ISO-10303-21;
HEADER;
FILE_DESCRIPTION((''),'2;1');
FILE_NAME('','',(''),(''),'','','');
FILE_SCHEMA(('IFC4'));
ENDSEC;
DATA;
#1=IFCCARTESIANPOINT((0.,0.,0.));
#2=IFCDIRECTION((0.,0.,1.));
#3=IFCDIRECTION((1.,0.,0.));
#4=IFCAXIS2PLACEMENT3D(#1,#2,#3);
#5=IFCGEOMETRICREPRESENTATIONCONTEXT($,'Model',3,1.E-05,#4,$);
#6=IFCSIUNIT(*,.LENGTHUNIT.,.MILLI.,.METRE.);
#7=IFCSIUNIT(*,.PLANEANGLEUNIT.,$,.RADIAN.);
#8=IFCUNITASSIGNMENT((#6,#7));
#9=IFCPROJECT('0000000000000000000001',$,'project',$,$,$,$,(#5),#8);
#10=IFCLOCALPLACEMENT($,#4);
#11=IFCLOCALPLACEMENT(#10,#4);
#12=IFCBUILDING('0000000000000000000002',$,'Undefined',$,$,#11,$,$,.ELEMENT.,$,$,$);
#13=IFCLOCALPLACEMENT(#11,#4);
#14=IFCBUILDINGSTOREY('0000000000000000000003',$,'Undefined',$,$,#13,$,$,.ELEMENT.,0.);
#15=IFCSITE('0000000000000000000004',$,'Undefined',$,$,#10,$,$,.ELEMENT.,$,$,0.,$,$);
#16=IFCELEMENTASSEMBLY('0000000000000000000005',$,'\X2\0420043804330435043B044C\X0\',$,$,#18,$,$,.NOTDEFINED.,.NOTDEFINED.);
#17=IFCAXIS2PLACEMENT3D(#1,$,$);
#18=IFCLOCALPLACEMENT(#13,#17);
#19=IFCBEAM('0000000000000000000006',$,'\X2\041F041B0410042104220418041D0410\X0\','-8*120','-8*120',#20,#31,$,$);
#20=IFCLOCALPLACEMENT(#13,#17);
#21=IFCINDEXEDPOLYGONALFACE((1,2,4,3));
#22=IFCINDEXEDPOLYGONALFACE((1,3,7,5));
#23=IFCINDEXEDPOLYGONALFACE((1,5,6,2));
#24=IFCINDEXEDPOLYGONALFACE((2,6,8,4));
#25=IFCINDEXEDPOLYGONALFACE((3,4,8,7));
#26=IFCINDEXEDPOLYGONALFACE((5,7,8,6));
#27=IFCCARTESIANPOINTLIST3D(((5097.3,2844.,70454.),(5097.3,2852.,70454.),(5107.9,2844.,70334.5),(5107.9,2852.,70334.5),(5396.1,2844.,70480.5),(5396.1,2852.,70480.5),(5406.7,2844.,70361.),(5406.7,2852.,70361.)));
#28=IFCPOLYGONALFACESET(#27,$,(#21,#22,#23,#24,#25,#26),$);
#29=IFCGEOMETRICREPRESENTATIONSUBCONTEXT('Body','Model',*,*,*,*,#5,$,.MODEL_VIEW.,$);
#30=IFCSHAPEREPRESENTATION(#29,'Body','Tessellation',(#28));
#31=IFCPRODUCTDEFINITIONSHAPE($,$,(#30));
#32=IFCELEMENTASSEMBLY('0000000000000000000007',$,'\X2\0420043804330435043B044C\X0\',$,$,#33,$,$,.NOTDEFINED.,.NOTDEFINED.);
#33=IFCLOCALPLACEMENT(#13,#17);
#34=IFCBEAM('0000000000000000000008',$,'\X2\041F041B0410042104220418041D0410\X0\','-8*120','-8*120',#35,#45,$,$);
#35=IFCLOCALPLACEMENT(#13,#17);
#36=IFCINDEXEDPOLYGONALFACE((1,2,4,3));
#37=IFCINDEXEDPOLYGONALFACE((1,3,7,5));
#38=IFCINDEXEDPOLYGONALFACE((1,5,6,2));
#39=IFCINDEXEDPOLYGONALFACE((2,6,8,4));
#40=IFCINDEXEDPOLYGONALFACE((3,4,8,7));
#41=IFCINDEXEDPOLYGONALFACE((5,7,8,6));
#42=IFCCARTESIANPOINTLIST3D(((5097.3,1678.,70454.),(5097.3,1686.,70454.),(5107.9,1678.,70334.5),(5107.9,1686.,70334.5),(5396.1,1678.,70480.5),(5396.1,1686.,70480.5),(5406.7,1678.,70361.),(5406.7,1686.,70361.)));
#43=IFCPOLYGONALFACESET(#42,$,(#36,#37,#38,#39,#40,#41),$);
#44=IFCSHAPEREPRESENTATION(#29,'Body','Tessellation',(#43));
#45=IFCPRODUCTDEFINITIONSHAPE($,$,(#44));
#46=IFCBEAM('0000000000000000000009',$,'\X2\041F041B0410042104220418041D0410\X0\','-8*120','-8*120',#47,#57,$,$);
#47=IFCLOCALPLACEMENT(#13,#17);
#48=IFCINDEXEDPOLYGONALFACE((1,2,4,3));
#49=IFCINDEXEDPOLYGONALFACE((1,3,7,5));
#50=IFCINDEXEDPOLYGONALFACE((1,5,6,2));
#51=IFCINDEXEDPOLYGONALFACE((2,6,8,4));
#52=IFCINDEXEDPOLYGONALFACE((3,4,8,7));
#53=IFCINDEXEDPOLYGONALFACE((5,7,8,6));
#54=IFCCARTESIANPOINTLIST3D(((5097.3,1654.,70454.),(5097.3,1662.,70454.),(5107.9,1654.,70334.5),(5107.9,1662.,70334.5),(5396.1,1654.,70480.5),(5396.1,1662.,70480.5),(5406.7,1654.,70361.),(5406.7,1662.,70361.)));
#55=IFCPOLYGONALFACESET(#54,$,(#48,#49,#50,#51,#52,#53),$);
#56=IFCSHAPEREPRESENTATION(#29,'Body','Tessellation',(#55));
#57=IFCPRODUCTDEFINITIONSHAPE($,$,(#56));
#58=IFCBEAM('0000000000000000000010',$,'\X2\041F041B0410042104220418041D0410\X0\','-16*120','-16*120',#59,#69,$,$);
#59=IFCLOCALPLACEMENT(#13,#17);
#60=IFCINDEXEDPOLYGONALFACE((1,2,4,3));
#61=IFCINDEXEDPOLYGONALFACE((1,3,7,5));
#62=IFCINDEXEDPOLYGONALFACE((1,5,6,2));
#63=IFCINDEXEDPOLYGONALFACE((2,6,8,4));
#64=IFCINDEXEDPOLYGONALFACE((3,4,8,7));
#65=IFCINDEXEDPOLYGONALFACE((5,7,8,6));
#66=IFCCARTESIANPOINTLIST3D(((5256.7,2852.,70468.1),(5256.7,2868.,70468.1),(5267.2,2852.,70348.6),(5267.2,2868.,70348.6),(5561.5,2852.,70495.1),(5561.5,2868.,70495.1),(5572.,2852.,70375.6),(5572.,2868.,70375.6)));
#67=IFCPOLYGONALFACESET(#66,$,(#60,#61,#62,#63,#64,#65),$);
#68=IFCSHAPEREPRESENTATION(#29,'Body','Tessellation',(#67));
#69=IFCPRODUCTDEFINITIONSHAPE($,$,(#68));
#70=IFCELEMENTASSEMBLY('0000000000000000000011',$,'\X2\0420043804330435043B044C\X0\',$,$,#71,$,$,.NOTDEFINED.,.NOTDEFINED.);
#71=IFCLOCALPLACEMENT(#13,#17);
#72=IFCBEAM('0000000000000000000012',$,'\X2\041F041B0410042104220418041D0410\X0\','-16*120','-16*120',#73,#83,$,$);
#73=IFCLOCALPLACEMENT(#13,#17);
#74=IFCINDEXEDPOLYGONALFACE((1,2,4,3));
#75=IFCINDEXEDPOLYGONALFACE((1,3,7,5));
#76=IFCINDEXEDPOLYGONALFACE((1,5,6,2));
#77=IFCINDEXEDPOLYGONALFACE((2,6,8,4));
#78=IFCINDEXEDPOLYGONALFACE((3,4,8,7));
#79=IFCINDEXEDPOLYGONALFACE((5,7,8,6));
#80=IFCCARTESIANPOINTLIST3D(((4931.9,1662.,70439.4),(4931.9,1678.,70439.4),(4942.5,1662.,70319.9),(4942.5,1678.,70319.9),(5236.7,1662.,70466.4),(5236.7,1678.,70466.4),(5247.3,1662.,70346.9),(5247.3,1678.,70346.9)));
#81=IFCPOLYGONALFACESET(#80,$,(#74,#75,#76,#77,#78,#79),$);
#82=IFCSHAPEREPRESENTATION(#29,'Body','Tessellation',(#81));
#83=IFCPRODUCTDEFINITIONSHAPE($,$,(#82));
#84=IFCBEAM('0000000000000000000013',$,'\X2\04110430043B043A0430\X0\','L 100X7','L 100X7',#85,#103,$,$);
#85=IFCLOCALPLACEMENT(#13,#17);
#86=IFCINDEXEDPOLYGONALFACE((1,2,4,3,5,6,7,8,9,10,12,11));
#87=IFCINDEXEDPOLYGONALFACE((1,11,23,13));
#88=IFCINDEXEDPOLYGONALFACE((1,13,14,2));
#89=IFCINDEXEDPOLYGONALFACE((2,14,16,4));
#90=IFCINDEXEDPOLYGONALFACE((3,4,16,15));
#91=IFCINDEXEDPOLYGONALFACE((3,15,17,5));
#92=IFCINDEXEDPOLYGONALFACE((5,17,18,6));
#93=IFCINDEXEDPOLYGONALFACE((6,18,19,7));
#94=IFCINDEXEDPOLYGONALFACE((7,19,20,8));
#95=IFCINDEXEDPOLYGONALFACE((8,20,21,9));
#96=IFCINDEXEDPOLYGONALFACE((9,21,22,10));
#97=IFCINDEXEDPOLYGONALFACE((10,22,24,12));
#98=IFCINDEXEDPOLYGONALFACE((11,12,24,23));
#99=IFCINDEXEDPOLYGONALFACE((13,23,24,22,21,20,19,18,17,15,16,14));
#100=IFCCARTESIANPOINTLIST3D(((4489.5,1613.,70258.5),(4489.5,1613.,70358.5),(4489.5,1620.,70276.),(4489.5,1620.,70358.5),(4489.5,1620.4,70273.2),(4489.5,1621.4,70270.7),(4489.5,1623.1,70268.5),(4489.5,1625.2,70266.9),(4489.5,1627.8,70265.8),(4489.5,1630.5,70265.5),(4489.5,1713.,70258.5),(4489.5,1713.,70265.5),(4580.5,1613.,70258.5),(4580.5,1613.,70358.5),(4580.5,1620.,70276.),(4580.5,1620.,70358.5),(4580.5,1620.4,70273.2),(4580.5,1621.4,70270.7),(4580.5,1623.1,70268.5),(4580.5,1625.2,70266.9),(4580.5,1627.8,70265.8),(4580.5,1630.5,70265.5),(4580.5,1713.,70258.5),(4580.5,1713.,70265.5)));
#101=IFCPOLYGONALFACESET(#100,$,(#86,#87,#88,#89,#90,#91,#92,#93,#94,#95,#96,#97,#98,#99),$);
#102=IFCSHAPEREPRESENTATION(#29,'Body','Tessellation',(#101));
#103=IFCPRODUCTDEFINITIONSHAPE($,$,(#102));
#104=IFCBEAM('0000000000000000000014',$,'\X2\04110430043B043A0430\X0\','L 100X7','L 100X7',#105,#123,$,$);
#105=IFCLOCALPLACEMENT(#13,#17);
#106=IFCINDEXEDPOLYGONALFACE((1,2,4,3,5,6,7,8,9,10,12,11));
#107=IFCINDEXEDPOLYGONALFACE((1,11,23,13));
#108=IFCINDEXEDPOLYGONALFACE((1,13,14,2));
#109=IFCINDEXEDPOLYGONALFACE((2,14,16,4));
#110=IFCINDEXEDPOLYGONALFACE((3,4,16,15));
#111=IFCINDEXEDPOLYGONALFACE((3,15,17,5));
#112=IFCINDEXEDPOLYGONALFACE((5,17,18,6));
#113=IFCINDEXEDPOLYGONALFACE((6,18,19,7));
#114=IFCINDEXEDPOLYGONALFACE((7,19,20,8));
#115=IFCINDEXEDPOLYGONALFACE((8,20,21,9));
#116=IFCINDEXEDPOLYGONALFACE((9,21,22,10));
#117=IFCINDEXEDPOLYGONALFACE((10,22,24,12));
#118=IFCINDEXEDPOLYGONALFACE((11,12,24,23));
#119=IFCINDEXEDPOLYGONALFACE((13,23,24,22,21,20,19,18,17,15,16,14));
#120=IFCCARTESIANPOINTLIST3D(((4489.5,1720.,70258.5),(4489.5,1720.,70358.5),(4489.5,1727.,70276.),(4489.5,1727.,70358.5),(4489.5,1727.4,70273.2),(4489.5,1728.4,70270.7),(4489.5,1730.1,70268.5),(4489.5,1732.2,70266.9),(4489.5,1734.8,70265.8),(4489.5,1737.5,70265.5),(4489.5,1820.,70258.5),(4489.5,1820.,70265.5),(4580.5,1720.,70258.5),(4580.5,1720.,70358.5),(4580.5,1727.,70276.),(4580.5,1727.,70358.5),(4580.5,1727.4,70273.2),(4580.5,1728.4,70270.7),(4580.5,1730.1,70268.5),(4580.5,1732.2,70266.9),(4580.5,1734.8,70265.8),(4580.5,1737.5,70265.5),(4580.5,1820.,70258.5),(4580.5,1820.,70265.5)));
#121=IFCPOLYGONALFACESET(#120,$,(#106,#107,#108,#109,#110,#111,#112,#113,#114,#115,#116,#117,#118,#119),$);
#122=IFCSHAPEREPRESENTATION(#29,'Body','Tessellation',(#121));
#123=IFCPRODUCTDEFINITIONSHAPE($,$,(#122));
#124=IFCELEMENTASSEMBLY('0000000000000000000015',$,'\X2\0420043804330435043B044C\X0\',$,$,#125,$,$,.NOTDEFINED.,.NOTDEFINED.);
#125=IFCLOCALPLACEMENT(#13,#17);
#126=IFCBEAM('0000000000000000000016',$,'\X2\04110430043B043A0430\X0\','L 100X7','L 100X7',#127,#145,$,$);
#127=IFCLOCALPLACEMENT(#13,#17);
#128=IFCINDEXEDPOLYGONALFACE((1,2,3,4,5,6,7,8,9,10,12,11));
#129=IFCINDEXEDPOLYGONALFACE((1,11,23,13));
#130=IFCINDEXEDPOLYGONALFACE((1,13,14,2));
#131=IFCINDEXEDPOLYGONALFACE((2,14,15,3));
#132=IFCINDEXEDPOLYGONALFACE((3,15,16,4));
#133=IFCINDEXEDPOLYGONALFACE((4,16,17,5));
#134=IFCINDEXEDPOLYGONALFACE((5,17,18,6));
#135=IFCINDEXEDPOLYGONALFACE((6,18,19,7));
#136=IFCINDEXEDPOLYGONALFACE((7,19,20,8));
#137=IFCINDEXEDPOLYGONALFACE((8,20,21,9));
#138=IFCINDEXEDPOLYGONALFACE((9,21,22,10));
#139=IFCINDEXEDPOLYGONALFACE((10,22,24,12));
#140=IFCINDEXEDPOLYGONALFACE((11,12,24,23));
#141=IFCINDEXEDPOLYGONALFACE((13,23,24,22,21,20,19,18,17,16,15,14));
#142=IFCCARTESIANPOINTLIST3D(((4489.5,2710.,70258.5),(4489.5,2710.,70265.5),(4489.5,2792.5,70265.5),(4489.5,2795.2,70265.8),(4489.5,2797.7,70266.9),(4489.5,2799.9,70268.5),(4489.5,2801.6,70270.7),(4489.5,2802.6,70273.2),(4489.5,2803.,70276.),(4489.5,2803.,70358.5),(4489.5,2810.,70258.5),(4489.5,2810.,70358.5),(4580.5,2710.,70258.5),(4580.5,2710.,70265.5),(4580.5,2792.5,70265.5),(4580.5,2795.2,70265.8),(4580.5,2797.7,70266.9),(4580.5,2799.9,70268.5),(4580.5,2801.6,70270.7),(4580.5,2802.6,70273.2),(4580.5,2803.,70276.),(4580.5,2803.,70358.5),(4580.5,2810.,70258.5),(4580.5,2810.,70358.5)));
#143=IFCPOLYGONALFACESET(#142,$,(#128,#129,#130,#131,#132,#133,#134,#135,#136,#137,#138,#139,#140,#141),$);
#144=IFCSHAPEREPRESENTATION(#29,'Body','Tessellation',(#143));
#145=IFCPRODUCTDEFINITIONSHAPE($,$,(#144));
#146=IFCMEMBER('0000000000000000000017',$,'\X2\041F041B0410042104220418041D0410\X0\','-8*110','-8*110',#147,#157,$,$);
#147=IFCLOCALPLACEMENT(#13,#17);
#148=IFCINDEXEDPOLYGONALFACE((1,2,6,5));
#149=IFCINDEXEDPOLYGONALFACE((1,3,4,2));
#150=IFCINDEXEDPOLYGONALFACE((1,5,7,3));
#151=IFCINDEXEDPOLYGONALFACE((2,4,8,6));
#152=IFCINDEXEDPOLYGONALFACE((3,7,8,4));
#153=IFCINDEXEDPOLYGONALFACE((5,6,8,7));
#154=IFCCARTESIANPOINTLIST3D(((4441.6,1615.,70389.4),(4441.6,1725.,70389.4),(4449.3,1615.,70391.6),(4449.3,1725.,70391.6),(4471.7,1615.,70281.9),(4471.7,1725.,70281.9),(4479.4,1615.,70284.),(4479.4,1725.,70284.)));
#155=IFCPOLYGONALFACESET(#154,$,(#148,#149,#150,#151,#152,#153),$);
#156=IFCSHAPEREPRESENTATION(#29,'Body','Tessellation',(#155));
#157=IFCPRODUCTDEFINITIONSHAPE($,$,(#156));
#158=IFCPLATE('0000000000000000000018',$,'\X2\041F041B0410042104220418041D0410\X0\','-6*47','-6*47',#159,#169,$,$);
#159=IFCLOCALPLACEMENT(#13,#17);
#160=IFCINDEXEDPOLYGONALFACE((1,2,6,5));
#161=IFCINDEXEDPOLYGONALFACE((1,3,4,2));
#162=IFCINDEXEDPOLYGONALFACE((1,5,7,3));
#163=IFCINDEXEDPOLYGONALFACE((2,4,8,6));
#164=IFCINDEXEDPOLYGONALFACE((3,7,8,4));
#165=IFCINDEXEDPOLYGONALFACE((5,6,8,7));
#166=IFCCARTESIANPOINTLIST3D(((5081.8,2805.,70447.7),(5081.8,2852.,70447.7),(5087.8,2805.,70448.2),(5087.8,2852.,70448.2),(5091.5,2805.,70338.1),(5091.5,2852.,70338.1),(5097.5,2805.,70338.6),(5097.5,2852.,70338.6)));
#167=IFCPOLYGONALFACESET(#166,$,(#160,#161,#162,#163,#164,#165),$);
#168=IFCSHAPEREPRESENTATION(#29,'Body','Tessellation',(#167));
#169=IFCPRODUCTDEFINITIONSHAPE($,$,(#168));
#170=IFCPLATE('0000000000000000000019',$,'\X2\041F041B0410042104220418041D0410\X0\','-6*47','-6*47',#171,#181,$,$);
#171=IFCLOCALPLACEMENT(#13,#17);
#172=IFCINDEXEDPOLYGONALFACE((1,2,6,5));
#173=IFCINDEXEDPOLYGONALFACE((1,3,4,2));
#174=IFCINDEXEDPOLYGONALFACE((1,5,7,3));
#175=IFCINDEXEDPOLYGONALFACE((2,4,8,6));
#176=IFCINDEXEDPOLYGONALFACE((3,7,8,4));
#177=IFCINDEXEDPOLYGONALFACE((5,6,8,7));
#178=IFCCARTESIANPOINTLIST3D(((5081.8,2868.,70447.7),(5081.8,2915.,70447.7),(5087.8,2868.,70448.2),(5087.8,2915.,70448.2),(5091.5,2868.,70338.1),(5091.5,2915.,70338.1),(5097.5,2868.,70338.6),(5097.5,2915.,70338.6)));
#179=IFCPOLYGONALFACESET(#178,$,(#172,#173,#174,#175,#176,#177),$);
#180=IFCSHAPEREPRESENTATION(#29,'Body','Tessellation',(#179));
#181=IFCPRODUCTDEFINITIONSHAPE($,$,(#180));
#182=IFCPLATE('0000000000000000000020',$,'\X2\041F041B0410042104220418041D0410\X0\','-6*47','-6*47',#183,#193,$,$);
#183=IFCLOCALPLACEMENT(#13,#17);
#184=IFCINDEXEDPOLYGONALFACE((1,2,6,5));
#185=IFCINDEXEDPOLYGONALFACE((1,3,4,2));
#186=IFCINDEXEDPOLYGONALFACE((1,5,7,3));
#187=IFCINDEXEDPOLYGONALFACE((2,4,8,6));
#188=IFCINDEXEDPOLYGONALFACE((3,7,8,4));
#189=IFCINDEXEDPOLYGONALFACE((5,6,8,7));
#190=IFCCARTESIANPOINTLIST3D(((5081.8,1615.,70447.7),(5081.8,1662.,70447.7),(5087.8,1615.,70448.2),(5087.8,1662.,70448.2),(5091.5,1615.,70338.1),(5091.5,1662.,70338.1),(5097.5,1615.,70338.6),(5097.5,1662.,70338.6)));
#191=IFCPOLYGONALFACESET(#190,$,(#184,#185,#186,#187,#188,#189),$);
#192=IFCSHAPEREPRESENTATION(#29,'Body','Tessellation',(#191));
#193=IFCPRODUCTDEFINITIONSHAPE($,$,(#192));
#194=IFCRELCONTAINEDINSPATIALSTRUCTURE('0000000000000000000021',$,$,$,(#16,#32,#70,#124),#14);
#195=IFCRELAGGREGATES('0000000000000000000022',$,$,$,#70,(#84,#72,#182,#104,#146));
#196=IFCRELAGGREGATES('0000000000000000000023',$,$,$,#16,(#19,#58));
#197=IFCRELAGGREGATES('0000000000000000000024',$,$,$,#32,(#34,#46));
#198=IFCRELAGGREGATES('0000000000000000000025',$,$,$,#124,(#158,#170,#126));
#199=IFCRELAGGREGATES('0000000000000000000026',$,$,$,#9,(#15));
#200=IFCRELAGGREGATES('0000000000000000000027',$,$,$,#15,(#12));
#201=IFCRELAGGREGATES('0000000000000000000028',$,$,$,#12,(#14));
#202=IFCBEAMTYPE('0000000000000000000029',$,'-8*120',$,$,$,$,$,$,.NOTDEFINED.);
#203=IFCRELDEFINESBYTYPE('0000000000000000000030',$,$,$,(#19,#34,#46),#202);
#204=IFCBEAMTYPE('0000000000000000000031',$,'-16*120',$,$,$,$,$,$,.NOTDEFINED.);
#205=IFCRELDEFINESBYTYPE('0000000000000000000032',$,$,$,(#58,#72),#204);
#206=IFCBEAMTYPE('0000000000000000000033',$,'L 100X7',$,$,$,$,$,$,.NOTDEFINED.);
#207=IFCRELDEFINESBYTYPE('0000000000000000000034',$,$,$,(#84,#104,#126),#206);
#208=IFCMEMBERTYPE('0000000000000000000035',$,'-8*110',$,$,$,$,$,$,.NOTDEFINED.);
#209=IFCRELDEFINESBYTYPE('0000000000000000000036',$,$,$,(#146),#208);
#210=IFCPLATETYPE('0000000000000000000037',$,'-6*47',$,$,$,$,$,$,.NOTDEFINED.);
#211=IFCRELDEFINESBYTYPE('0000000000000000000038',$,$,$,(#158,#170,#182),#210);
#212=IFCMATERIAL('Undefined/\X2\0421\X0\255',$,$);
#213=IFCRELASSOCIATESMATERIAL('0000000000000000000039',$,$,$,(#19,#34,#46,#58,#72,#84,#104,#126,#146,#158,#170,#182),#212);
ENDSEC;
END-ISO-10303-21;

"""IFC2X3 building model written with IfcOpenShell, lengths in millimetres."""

from ifc_helpers import new_model, si_unit, frame, origin_with_axes, origin_2d_with_axis, place, context, subcontext, project, spatial, polyline, rectangle, l_section, outline, extrude, boolean, material, type_object, element, aggregate, save


model = new_model("IFC2X3")

# Units and contexts
model_context = context("Model", 3, precision=1e-05, world=origin_with_axes())
body_context = subcontext(model_context, "Body", "Model", "MODEL_VIEW")
ifc_project = project(units=[si_unit("LENGTHUNIT", "METRE", prefix="MILLI"), si_unit("PLANEANGLEUNIT", "RADIAN")], contexts=[model_context])

# Site, building, storey
site_placement = place(None, origin_with_axes())
site = spatial("IfcSite", under=ifc_project, at=site_placement, Name="Undefined", CompositionType="ELEMENT", RefElevation=0.0)
building_placement = place(site_placement, origin_with_axes())
building = spatial("IfcBuilding", under=site, at=building_placement, Name="Undefined", CompositionType="ELEMENT")
storey_placement = place(building_placement, origin_with_axes())
storey = spatial("IfcBuildingStorey", under=building, at=storey_placement, Name="Undefined", CompositionType="ELEMENT", Elevation=0.0)

# Element assembly, beam
assembly_1_placement = place(storey_placement, origin_with_axes())
assembly_1 = element("IfcElementAssembly", 1, at=assembly_1_placement, inside=storey, Name="Ригель", AssemblyPlace="NOTDEFINED", PredefinedType="NOTDEFINED")
ifc_material_1 = material(Name="Undefined/С255")
beam_type_1 = type_object("IfcBeamType", Name="-8*120", PredefinedType="NOTDEFINED")
beam_1_placement = place(assembly_1_placement, frame((5102.6, 2848.0, 70394.3), z_axis=(0.088152, 0.0, -0.996107), x_axis=(0.996107, 0.0, 0.088152)))
beam_1 = element("IfcBeam", 2, at=beam_1_placement, type_object=beam_type_1, material=ifc_material_1, Name="ПЛАСТИНА", Description="-8*120", ObjectType="-8*120", context=body_context, shape_type="SweptSolid", body=[
    extrude(rectangle(XDim=8.0, YDim=120.0, at=origin_2d_with_axis()), frame((300.0, 0.0, 0.0), z_axis=(-1.0, 0.0, 0.0), x_axis=(0.0, -1.0, 0.0)), (0.0, 0.0, 1.0), 300.0),
])

# Element assembly, beams
assembly_2_placement = place(storey_placement, origin_with_axes())
assembly_2 = element("IfcElementAssembly", 3, at=assembly_2_placement, inside=storey, Name="Ригель", AssemblyPlace="NOTDEFINED", PredefinedType="NOTDEFINED")
beam_2_placement = place(assembly_2_placement, frame((5102.6, 1682.0, 70394.3), z_axis=(0.088152, 0.0, -0.996107), x_axis=(0.996107, 0.0, 0.088152)))
beam_2 = element("IfcBeam", 4, at=beam_2_placement, type_object=beam_type_1, material=ifc_material_1, Name="ПЛАСТИНА", Description="-8*120", ObjectType="-8*120", context=body_context, shape_type="SweptSolid", body=[
    extrude(rectangle(XDim=8.0, YDim=120.0, at=origin_2d_with_axis()), frame((300.0, 0.0, 0.0), z_axis=(-1.0, 0.0, 0.0), x_axis=(0.0, -1.0, 0.0)), (0.0, 0.0, 1.0), 300.0),
])
beam_3_placement = place(assembly_2_placement, frame((5102.6, 1658.0, 70394.3), z_axis=(0.088152, 0.0, -0.996107), x_axis=(0.996107, 0.0, 0.088152)))
beam_3 = element("IfcBeam", 5, at=beam_3_placement, type_object=beam_type_1, material=ifc_material_1, Name="ПЛАСТИНА", Description="-8*120", ObjectType="-8*120", context=body_context, shape_type="SweptSolid", body=[
    extrude(rectangle(XDim=8.0, YDim=120.0, at=origin_2d_with_axis()), frame((300.0, 0.0, 0.0), z_axis=(-1.0, 0.0, 0.0), x_axis=(0.0, -1.0, 0.0)), (0.0, 0.0, 1.0), 300.0),
])

# Beam
beam_type_2 = type_object("IfcBeamType", Name="-16*120", PredefinedType="NOTDEFINED")
beam_4_placement = place(assembly_1_placement, frame((5261.9, 2860.0, 70408.4), z_axis=(0.088152, 0.0, -0.996107), x_axis=(0.996107, 0.0, 0.088152)))
beam_4 = element("IfcBeam", 6, at=beam_4_placement, type_object=beam_type_2, material=ifc_material_1, Name="ПЛАСТИНА", Description="-16*120", ObjectType="-16*120", context=body_context, shape_type="SweptSolid", body=[
    extrude(rectangle(XDim=16.0, YDim=120.0, at=origin_2d_with_axis()), frame((306.0, 0.0, 0.0), z_axis=(-1.0, 0.0, 0.0), x_axis=(0.0, -1.0, 0.0)), (0.0, 0.0, 1.0), 306.0),
])

# Element assembly, beams
assembly_3_placement = place(storey_placement, origin_with_axes())
assembly_3 = element("IfcElementAssembly", 7, at=assembly_3_placement, inside=storey, Name="Ригель", AssemblyPlace="NOTDEFINED", PredefinedType="NOTDEFINED")
beam_5_placement = place(assembly_3_placement, frame((4937.2, 1670.0, 70379.6), z_axis=(0.088152, 0.0, -0.996107), x_axis=(0.996107, 0.0, 0.088152)))
beam_5 = element("IfcBeam", 8, at=beam_5_placement, type_object=beam_type_2, material=ifc_material_1, Name="ПЛАСТИНА", Description="-16*120", ObjectType="-16*120", context=body_context, shape_type="SweptSolid", body=[
    extrude(rectangle(XDim=16.0, YDim=120.0, at=origin_2d_with_axis()), frame((306.0, 0.0, 0.0), z_axis=(-1.0, 0.0, 0.0), x_axis=(0.0, -1.0, 0.0)), (0.0, 0.0, 1.0), 306.0),
])
beam_type_3 = type_object("IfcBeamType", Name="L 100X7", PredefinedType="NOTDEFINED")
beam_6_placement = place(assembly_3_placement, frame((4489.5, 1663.0, 70308.5), z_axis=(0.0, 1.0, 0.0), x_axis=(1.0, 0.0, 0.0)))
beam_6 = element("IfcBeam", 9, at=beam_6_placement, type_object=beam_type_3, material=ifc_material_1, Name="Балка", Description="L 100X7", ObjectType="L 100X7", context=body_context, shape_type="SweptSolid", body=[
    extrude(l_section(Depth=100.0, Width=100.0, Thickness=7.0, FilletRadius=10.5, at=origin_2d_with_axis()), frame((91.0, 0.0, 0.0), z_axis=(-1.0, 0.0, 0.0), x_axis=(0.0, -1.0, 0.0)), (0.0, 0.0, 1.0), 91.0),
])
beam_7_placement = place(assembly_3_placement, frame((4489.5, 1770.0, 70308.5), z_axis=(0.0, 1.0, 0.0), x_axis=(1.0, 0.0, 0.0)))
beam_7 = element("IfcBeam", 10, at=beam_7_placement, type_object=beam_type_3, material=ifc_material_1, Name="Балка", Description="L 100X7", ObjectType="L 100X7", context=body_context, shape_type="SweptSolid", body=[
    extrude(l_section(Depth=100.0, Width=100.0, Thickness=7.0, FilletRadius=10.5, at=origin_2d_with_axis()), frame((91.0, 0.0, 0.0), z_axis=(-1.0, 0.0, 0.0), x_axis=(0.0, -1.0, 0.0)), (0.0, 0.0, 1.0), 91.0),
])

# Element assembly, beam
assembly_4_placement = place(storey_placement, origin_with_axes())
assembly_4 = element("IfcElementAssembly", 11, at=assembly_4_placement, inside=storey, Name="Ригель", AssemblyPlace="NOTDEFINED", PredefinedType="NOTDEFINED")
beam_8_placement = place(assembly_4_placement, frame((4489.5, 2760.0, 70308.5), z_axis=(0.0, 0.0, 1.0), x_axis=(1.0, 0.0, 0.0)))
beam_8 = element("IfcBeam", 12, at=beam_8_placement, type_object=beam_type_3, material=ifc_material_1, Name="Балка", Description="L 100X7", ObjectType="L 100X7", context=body_context, shape_type="SweptSolid", body=[
    extrude(l_section(Depth=100.0, Width=100.0, Thickness=7.0, FilletRadius=10.5, at=origin_2d_with_axis()), frame((91.0, 0.0, 0.0), z_axis=(-1.0, 0.0, 0.0), x_axis=(0.0, -1.0, 0.0)), (0.0, 0.0, 1.0), 91.0),
])

# Member
member_type = type_object("IfcMemberType", Name="-8*110", PredefinedType="NOTDEFINED")
member_placement = place(assembly_3_placement, frame((4475.6, 1670.0, 70282.9), z_axis=(0.0, -1.0, 0.0), x_axis=(-0.269248, 0.0, 0.963071)))
member = element("IfcMember", 13, at=member_placement, type_object=member_type, material=ifc_material_1, Name="ПЛАСТИНА", Description="-8*110", ObjectType="-8*110", context=body_context, shape_type="SweptSolid", body=[
    extrude(rectangle(XDim=8.0, YDim=110.0, at=origin_2d_with_axis()), frame((111.7, 0.0, 0.0), z_axis=(-1.0, 0.0, 0.0), x_axis=(0.0, -1.0, 0.0)), (0.0, 0.0, 1.0), 111.7),
])

# Plates
plate_type_1 = type_object("IfcPlateType", Name="-6*47", PredefinedType="NOTDEFINED")
plate_1_placement = place(assembly_4_placement, frame((5084.8, 2805.0, 70447.9), z_axis=(0.996107, 0.0, 0.088152), x_axis=(0.088152, 0.0, -0.996107)))
plate_1 = element("IfcPlate", 14, at=plate_1_placement, type_object=plate_type_1, material=ifc_material_1, Name="ПЛАСТИНА", Description="-6*47", ObjectType="-6*47", context=body_context, shape_type="CSG", body=[
    boolean("DIFFERENCE", extrude(outline(polyline([(0.0, 0.0), (110.0, 0.0), (110.0, 110.0), (0.0, 110.0), (0.0, 0.0)])), frame((0.0, 0.0, -3.0), z_axis=(0.0, 0.0, 1.0), x_axis=(1.0, 0.0, 0.0)), (0.0, 0.0, 1.0), 6.0), extrude(rectangle(XDim=26.0, YDim=130.0, at=origin_2d_with_axis()), frame((55.0, 47.0, 0.0), z_axis=(0.0, 1.0, 0.0), x_axis=(0.0, 0.0, -1.0)), (0.0, 0.0, 1.0), 66.0)),
])
plate_2_placement = place(assembly_4_placement, frame((5084.8, 2805.0, 70447.9), z_axis=(0.996107, 0.0, 0.088152), x_axis=(0.088152, 0.0, -0.996107)))
plate_2 = element("IfcPlate", 15, at=plate_2_placement, type_object=plate_type_1, material=ifc_material_1, Name="ПЛАСТИНА", Description="-6*47", ObjectType="-6*47", context=body_context, shape_type="CSG", body=[
    boolean("DIFFERENCE", extrude(outline(polyline([(0.0, 0.0), (110.0, 0.0), (110.0, 110.0), (0.0, 110.0), (0.0, 0.0)])), frame((0.0, 0.0, -3.0), z_axis=(0.0, 0.0, 1.0), x_axis=(1.0, 0.0, 0.0)), (0.0, 0.0, 1.0), 6.0), extrude(rectangle(XDim=26.0, YDim=130.0, at=origin_2d_with_axis()), frame((55.0, -3.0, 0.0), z_axis=(0.0, 1.0, 0.0), x_axis=(0.0, 0.0, -1.0)), (0.0, 0.0, 1.0), 66.0)),
])
plate_3_placement = place(assembly_3_placement, frame((5084.8, 1615.0, 70447.9), z_axis=(0.996107, 0.0, 0.088152), x_axis=(0.088152, 0.0, -0.996107)))
plate_3 = element("IfcPlate", 16, at=plate_3_placement, type_object=plate_type_1, material=ifc_material_1, Name="ПЛАСТИНА", Description="-6*47", ObjectType="-6*47", context=body_context, shape_type="CSG", body=[
    boolean("DIFFERENCE", extrude(outline(polyline([(0.0, 0.0), (110.0, 0.0), (110.0, 110.0), (0.0, 110.0), (0.0, 0.0)])), frame((0.0, 0.0, -3.0), z_axis=(0.0, 0.0, 1.0), x_axis=(1.0, 0.0, 0.0)), (0.0, 0.0, 1.0), 6.0), extrude(rectangle(XDim=26.0, YDim=130.0, at=origin_2d_with_axis()), frame((55.0, 47.0, 0.0), z_axis=(0.0, 1.0, 0.0), x_axis=(0.0, 0.0, -1.0)), (0.0, 0.0, 1.0), 66.0)),
])
aggregate(assembly_3, [beam_6, beam_5, plate_3, beam_7, member])

aggregate(assembly_1, [beam_1, beam_4])
aggregate(assembly_2, [beam_2, beam_3])
aggregate(assembly_4, [plate_1, plate_2, beam_8])

save(model, "model.ifc")
